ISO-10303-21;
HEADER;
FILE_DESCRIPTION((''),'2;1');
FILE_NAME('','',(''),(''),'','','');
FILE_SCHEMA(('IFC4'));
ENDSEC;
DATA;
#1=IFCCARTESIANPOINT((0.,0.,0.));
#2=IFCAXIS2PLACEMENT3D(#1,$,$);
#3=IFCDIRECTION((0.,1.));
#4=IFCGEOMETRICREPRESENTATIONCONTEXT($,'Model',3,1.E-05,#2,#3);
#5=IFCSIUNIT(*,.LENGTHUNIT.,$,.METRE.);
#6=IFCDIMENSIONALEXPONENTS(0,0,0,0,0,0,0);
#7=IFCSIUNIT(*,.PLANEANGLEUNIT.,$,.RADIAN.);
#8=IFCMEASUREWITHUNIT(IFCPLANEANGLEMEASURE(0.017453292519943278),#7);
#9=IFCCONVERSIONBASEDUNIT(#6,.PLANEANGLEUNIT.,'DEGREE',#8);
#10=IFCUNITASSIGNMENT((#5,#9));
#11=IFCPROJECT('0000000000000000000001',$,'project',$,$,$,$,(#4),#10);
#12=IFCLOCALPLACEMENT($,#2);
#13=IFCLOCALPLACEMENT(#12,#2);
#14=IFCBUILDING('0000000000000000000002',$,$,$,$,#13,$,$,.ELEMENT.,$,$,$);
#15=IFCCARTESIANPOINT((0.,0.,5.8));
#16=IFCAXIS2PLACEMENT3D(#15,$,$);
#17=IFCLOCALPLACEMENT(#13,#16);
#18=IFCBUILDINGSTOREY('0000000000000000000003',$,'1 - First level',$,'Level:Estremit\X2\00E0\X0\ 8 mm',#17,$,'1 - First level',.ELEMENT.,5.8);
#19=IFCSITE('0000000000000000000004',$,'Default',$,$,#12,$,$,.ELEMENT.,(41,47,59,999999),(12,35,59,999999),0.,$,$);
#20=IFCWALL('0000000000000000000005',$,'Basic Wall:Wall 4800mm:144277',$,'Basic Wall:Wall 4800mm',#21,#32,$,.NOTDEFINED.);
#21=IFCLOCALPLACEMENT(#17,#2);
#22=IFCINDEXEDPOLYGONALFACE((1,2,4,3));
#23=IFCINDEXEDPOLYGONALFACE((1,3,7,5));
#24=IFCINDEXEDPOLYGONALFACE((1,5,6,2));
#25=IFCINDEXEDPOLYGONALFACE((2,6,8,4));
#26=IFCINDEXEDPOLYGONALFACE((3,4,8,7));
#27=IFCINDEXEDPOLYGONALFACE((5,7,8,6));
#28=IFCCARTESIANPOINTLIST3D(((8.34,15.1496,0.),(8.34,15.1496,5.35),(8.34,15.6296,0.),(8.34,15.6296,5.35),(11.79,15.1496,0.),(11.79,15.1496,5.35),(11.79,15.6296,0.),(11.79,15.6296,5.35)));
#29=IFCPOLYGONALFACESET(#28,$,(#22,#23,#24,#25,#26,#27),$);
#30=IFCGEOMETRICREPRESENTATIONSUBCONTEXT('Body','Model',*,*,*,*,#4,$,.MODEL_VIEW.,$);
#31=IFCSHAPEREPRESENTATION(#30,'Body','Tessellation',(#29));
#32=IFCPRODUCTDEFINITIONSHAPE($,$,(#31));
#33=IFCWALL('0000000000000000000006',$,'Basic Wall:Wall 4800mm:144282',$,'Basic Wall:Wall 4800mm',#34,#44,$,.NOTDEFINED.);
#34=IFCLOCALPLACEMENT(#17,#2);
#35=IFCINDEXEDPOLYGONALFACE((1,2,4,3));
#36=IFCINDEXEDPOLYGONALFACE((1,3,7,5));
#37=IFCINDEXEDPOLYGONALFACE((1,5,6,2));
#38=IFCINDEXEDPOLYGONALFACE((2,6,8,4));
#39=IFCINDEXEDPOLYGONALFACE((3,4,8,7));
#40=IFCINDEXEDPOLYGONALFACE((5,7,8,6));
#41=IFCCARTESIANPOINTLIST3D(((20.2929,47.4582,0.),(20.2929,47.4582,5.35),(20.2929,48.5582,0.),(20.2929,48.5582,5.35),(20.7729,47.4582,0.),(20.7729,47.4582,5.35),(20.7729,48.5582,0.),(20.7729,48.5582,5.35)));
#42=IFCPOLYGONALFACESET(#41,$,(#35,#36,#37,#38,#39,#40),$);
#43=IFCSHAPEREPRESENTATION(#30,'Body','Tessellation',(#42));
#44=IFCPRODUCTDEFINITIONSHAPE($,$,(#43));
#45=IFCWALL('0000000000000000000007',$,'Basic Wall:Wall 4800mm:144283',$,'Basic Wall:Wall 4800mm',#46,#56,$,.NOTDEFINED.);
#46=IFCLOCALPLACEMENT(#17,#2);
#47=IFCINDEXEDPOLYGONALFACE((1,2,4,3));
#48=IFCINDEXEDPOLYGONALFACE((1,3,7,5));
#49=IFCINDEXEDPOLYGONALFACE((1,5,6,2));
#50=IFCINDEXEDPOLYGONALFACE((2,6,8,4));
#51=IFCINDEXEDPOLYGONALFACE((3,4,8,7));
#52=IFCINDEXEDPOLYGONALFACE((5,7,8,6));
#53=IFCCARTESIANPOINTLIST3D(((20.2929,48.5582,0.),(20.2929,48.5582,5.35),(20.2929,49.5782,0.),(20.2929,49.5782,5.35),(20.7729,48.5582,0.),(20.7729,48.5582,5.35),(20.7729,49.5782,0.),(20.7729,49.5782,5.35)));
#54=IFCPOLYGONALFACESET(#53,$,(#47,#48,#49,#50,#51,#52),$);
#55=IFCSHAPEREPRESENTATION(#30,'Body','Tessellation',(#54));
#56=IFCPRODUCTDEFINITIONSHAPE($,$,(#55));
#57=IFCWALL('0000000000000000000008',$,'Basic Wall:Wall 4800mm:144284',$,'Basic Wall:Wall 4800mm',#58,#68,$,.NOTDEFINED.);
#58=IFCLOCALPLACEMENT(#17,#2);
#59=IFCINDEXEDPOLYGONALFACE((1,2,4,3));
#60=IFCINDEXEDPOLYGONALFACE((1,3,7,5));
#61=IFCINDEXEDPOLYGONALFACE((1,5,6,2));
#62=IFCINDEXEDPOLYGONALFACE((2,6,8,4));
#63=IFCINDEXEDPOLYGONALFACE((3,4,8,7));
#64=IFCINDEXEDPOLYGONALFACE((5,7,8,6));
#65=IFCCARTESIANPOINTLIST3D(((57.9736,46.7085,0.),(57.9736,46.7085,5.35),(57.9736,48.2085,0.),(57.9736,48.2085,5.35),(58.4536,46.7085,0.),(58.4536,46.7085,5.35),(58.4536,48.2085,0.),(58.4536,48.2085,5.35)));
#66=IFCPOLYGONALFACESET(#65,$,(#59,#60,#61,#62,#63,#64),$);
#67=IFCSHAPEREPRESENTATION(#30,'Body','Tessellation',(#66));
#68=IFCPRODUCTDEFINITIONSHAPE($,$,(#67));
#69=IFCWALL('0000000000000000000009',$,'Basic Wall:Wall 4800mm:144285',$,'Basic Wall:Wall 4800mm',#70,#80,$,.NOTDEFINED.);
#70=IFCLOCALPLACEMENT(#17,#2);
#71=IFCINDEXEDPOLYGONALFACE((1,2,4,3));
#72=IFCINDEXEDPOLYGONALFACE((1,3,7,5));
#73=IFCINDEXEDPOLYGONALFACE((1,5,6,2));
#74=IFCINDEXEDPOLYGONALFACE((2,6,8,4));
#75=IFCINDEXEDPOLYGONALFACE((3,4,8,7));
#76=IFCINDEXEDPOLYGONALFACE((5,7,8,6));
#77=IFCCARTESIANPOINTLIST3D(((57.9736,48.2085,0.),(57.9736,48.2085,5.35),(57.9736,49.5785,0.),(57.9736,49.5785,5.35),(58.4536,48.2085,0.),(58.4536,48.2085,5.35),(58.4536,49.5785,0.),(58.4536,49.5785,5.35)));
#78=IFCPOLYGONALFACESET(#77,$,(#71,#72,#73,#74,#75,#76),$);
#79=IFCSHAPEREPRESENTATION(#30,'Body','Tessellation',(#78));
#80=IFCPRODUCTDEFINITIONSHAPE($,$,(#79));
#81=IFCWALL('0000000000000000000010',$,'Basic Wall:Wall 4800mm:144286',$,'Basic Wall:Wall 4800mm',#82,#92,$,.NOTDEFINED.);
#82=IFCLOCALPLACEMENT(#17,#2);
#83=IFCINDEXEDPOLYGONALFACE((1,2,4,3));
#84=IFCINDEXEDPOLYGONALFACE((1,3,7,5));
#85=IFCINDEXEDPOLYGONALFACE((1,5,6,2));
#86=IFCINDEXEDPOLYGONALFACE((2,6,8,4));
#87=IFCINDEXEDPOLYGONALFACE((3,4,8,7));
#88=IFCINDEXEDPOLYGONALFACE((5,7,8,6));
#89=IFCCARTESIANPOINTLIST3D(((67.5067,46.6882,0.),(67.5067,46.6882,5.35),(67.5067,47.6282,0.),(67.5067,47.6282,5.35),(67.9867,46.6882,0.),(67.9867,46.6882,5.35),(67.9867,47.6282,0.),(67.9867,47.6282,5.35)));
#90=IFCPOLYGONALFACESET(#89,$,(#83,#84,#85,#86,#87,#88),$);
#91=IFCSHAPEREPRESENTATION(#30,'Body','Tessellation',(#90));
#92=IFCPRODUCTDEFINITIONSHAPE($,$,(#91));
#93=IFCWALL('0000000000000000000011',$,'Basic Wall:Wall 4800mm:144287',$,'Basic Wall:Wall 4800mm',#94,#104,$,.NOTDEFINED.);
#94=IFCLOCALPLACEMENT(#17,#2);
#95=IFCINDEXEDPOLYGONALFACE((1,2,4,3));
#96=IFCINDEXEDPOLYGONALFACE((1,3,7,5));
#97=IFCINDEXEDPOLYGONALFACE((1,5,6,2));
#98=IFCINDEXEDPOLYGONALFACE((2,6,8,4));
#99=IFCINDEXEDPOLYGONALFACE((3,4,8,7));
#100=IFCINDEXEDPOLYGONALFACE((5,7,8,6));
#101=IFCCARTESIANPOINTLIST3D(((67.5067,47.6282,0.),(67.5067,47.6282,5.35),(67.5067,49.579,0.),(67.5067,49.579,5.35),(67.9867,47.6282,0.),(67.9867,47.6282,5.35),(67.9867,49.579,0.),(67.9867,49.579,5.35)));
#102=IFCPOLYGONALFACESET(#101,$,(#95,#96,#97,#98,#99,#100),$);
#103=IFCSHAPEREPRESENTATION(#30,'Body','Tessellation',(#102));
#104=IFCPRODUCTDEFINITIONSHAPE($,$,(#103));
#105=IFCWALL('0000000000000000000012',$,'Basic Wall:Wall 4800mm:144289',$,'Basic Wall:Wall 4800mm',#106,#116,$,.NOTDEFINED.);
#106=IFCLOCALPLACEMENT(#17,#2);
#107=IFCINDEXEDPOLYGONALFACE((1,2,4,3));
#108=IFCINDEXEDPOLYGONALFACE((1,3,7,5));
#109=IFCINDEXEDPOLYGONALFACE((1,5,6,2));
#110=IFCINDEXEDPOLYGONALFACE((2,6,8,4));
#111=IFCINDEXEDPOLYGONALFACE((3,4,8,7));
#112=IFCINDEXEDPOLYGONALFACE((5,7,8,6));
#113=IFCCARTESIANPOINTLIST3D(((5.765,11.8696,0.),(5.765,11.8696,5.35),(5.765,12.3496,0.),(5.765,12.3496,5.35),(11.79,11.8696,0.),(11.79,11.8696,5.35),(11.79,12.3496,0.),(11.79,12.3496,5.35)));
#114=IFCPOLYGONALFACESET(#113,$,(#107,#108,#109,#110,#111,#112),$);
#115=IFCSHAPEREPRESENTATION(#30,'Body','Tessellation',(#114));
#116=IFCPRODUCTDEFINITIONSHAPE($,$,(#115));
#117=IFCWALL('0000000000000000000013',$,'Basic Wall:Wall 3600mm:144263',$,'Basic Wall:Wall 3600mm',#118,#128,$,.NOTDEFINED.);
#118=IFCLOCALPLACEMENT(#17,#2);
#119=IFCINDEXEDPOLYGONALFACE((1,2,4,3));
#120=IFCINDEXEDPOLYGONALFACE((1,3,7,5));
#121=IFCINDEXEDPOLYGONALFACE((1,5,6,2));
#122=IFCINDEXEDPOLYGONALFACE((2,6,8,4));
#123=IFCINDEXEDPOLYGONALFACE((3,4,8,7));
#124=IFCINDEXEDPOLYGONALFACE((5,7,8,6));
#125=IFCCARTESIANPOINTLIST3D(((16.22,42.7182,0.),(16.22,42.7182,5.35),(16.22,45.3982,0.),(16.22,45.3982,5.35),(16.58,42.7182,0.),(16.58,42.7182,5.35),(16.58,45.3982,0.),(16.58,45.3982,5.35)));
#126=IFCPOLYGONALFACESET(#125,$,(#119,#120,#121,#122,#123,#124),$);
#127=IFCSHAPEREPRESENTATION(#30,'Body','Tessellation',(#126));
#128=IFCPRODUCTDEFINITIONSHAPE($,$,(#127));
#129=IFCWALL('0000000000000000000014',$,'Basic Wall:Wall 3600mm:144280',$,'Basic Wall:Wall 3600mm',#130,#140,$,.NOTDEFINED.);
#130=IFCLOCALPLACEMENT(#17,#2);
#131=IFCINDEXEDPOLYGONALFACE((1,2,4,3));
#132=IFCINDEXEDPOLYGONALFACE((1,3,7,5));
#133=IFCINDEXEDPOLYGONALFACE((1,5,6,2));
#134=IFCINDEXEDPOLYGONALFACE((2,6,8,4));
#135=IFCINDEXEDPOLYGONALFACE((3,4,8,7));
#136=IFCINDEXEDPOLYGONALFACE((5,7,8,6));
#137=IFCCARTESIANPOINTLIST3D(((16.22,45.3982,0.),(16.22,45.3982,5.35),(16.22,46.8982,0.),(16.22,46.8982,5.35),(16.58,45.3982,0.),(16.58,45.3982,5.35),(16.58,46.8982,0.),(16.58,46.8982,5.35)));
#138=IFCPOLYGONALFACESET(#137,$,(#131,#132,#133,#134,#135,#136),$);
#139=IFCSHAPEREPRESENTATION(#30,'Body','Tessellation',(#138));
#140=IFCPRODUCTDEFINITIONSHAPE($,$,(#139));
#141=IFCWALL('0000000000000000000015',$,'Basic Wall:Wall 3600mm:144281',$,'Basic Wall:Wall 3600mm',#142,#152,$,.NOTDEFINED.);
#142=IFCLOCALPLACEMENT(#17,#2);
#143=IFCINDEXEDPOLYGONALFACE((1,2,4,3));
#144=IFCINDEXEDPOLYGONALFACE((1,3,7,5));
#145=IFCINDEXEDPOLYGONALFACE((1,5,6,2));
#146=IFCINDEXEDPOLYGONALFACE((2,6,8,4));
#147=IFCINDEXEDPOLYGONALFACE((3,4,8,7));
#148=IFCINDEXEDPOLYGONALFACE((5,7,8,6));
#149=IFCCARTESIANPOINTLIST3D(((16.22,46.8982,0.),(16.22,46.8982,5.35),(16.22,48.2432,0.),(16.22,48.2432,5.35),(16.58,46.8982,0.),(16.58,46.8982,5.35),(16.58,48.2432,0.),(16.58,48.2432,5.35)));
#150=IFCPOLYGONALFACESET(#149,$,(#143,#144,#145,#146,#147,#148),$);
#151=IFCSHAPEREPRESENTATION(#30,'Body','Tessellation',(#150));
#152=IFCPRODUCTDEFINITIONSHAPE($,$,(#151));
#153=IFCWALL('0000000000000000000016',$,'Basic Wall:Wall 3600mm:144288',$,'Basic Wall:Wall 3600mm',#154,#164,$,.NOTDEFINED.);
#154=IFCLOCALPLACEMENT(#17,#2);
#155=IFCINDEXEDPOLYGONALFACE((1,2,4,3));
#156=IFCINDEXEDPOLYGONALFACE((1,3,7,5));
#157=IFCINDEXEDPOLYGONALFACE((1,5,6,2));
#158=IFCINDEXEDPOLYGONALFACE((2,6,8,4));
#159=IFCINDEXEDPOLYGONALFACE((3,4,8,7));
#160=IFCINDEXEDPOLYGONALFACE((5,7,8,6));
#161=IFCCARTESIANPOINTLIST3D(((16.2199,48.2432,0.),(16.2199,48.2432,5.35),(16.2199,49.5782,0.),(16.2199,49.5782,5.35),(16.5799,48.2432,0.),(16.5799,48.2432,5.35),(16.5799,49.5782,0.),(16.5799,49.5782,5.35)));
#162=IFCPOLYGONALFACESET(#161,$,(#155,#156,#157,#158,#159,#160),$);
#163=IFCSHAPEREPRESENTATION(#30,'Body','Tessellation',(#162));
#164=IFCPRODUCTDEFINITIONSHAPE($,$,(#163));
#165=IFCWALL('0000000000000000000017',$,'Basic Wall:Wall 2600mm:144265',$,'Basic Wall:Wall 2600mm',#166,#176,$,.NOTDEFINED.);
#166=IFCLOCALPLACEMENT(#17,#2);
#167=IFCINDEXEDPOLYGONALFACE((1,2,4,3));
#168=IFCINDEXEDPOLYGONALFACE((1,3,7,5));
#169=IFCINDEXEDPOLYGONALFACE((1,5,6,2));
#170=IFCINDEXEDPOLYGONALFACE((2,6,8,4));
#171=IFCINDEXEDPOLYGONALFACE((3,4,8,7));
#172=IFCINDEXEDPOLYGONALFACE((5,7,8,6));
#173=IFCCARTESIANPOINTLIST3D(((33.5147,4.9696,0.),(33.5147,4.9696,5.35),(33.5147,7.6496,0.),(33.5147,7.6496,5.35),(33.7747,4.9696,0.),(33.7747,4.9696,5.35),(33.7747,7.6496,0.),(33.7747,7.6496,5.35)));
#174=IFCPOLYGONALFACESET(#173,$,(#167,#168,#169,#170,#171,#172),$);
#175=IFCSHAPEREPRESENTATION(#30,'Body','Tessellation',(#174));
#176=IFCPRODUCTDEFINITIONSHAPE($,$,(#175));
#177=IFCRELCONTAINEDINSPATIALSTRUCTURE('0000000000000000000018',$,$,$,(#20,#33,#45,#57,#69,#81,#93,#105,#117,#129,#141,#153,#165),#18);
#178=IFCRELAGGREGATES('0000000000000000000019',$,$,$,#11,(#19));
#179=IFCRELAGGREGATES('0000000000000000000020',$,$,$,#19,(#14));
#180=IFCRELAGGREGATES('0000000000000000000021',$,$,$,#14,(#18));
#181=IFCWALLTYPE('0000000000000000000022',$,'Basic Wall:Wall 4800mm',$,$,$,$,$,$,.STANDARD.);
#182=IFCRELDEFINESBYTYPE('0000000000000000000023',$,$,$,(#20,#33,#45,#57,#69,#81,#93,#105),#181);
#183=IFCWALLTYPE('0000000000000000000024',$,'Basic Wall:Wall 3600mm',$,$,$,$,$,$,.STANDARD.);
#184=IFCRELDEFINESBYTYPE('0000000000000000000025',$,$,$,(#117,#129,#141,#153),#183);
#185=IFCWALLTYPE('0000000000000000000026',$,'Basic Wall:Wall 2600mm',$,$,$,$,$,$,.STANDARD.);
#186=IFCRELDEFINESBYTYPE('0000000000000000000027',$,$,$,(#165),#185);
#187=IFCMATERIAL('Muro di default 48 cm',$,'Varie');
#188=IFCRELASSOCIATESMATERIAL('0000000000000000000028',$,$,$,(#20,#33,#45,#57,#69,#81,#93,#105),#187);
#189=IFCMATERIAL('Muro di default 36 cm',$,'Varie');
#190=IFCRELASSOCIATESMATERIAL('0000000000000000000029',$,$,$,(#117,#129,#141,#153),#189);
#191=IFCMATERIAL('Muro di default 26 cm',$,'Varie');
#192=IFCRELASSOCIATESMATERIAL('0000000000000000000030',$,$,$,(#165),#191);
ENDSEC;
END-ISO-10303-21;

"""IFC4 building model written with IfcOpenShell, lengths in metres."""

from ifc_helpers import new_model, entity, si_unit, converted_unit, direction, frame, origin, place, context, subcontext, project, spatial, indexed_curve, outline, extrude, material, type_object, element, save


model = new_model("IFC4")

# Units and contexts
model_context = context("Model", 3, precision=1e-05, world=origin(), true_north=direction((0.0, 1.0)))
body_context = subcontext(model_context, "Body", "Model", "MODEL_VIEW")
ifc_project = project(units=[si_unit("LENGTHUNIT", "METRE"), converted_unit("PLANEANGLEUNIT", "DEGREE", entity("IfcPlaneAngleMeasure", 0.017453292519943278), si_unit("PLANEANGLEUNIT", "RADIAN"), dimensions=[0, 0, 0, 0, 0, 0, 0])], contexts=[model_context])

# Site, building, storey
site_placement = place(None, origin())
site = spatial("IfcSite", under=ifc_project, at=site_placement, Name="Default", CompositionType="ELEMENT", RefLatitude=(41, 47, 59, 999999), RefLongitude=(12, 35, 59, 999999), RefElevation=0.0)
building_placement = place(site_placement, origin())
building = spatial("IfcBuilding", under=site, at=building_placement, CompositionType="ELEMENT")
storey_placement = place(building_placement, frame((0.0, 0.0, 5.8)))
storey = spatial("IfcBuildingStorey", under=building, at=storey_placement, Name="1 - First level", ObjectType="Level:Estremità 8 mm", LongName="1 - First level", CompositionType="ELEMENT", Elevation=5.8)

# Walls
ifc_material_1 = material(Name="Muro di default 48 cm", Category="Varie")
wall_type_1 = type_object("IfcWallType", Name="Basic Wall:Wall 4800mm", PredefinedType="STANDARD")
wall_1_placement = place(storey_placement, frame((8.34, 15.3896, 0.0)))
element("IfcWall", 1, at=wall_1_placement, inside=storey, type_object=wall_type_1, material=ifc_material_1, Name="Basic Wall:Wall 4800mm:144277", ObjectType="Basic Wall:Wall 4800mm", PredefinedType="NOTDEFINED", context=body_context, shape_type="SweptSolid", body=[
    extrude(outline(indexed_curve([(3.45, 0.24), (0.0, 0.24), (0.0, -0.24), (3.45, -0.24), (3.45, 0.24)], self_intersect=False)), origin(), (0.0, 0.0, 1.0), 5.35),
])
wall_2_placement = place(storey_placement, frame((20.5329, 47.4582, 0.0), z_axis=(0.0, 0.0, 1.0), x_axis=(0.0, 1.0, 0.0)))
element("IfcWall", 2, at=wall_2_placement, inside=storey, type_object=wall_type_1, material=ifc_material_1, Name="Basic Wall:Wall 4800mm:144282", ObjectType="Basic Wall:Wall 4800mm", PredefinedType="NOTDEFINED", context=body_context, shape_type="SweptSolid", body=[
    extrude(outline(indexed_curve([(1.1, 0.24), (0.0, 0.24), (0.0, -0.24), (1.1, -0.24), (1.1, 0.24)], self_intersect=False)), origin(), (0.0, 0.0, 1.0), 5.35),
])
wall_3_placement = place(storey_placement, frame((20.5329, 48.5582, 0.0), z_axis=(0.0, 0.0, 1.0), x_axis=(0.0, 1.0, 0.0)))
element("IfcWall", 3, at=wall_3_placement, inside=storey, type_object=wall_type_1, material=ifc_material_1, Name="Basic Wall:Wall 4800mm:144283", ObjectType="Basic Wall:Wall 4800mm", PredefinedType="NOTDEFINED", context=body_context, shape_type="SweptSolid", body=[
    extrude(outline(indexed_curve([(1.02, 0.24), (0.0, 0.24), (0.0, -0.24), (1.02, -0.24), (1.02, 0.24)], self_intersect=False)), origin(), (0.0, 0.0, 1.0), 5.35),
])
wall_4_placement = place(storey_placement, frame((58.2136, 46.7085, 0.0), z_axis=(0.0, 0.0, 1.0), x_axis=(0.0, 1.0, 0.0)))
element("IfcWall", 4, at=wall_4_placement, inside=storey, type_object=wall_type_1, material=ifc_material_1, Name="Basic Wall:Wall 4800mm:144284", ObjectType="Basic Wall:Wall 4800mm", PredefinedType="NOTDEFINED", context=body_context, shape_type="SweptSolid", body=[
    extrude(outline(indexed_curve([(1.5, 0.24), (0.0, 0.24), (0.0, -0.24), (1.5, -0.24), (1.5, 0.24)], self_intersect=False)), origin(), (0.0, 0.0, 1.0), 5.35),
])
wall_5_placement = place(storey_placement, frame((58.2136, 48.2085, 0.0), z_axis=(0.0, 0.0, 1.0), x_axis=(0.0, 1.0, 0.0)))
element("IfcWall", 5, at=wall_5_placement, inside=storey, type_object=wall_type_1, material=ifc_material_1, Name="Basic Wall:Wall 4800mm:144285", ObjectType="Basic Wall:Wall 4800mm", PredefinedType="NOTDEFINED", context=body_context, shape_type="SweptSolid", body=[
    extrude(outline(indexed_curve([(1.37, 0.24), (0.0, 0.24), (0.0, -0.24), (1.37, -0.24), (1.37, 0.24)], self_intersect=False)), origin(), (0.0, 0.0, 1.0), 5.35),
])
wall_6_placement = place(storey_placement, frame((67.7467, 46.6882, 0.0), z_axis=(0.0, 0.0, 1.0), x_axis=(0.0, 1.0, 0.0)))
element("IfcWall", 6, at=wall_6_placement, inside=storey, type_object=wall_type_1, material=ifc_material_1, Name="Basic Wall:Wall 4800mm:144286", ObjectType="Basic Wall:Wall 4800mm", PredefinedType="NOTDEFINED", context=body_context, shape_type="SweptSolid", body=[
    extrude(outline(indexed_curve([(0.94, 0.24), (0.0, 0.24), (0.0, -0.24), (0.94, -0.24), (0.94, 0.24)], self_intersect=False)), origin(), (0.0, 0.0, 1.0), 5.35),
])
wall_7_placement = place(storey_placement, frame((67.7467, 47.6282, 0.0), z_axis=(0.0, 0.0, 1.0), x_axis=(0.0, 1.0, 0.0)))
element("IfcWall", 7, at=wall_7_placement, inside=storey, type_object=wall_type_1, material=ifc_material_1, Name="Basic Wall:Wall 4800mm:144287", ObjectType="Basic Wall:Wall 4800mm", PredefinedType="NOTDEFINED", context=body_context, shape_type="SweptSolid", body=[
    extrude(outline(indexed_curve([(1.9508, 0.24), (0.0, 0.24), (0.0, -0.24), (1.9508, -0.24), (1.9508, 0.24)], self_intersect=False)), origin(), (0.0, 0.0, 1.0), 5.35),
])
wall_8_placement = place(storey_placement, frame((5.765, 12.1096, 0.0)))
element("IfcWall", 8, at=wall_8_placement, inside=storey, type_object=wall_type_1, material=ifc_material_1, Name="Basic Wall:Wall 4800mm:144289", ObjectType="Basic Wall:Wall 4800mm", PredefinedType="NOTDEFINED", context=body_context, shape_type="SweptSolid", body=[
    extrude(outline(indexed_curve([(6.025, 0.24), (0.0, 0.24), (0.0, -0.24), (6.025, -0.24), (6.025, 0.24)], self_intersect=False)), origin(), (0.0, 0.0, 1.0), 5.35),
])
ifc_material_2 = material(Name="Muro di default 36 cm", Category="Varie")
wall_type_2 = type_object("IfcWallType", Name="Basic Wall:Wall 3600mm", PredefinedType="STANDARD")
wall_9_placement = place(storey_placement, frame((16.4, 42.7182, 0.0), z_axis=(0.0, 0.0, 1.0), x_axis=(0.0, 1.0, 0.0)))
element("IfcWall", 9, at=wall_9_placement, inside=storey, type_object=wall_type_2, material=ifc_material_2, Name="Basic Wall:Wall 3600mm:144263", ObjectType="Basic Wall:Wall 3600mm", PredefinedType="NOTDEFINED", context=body_context, shape_type="SweptSolid", body=[
    extrude(outline(indexed_curve([(2.68, 0.18), (0.0, 0.18), (0.0, -0.18), (2.68, -0.18), (2.68, 0.18)], self_intersect=False)), origin(), (0.0, 0.0, 1.0), 5.35),
])
wall_10_placement = place(storey_placement, frame((16.4, 45.3982, 0.0), z_axis=(0.0, 0.0, 1.0), x_axis=(0.0, 1.0, 0.0)))
element("IfcWall", 10, at=wall_10_placement, inside=storey, type_object=wall_type_2, material=ifc_material_2, Name="Basic Wall:Wall 3600mm:144280", ObjectType="Basic Wall:Wall 3600mm", PredefinedType="NOTDEFINED", context=body_context, shape_type="SweptSolid", body=[
    extrude(outline(indexed_curve([(1.5, 0.18), (0.0, 0.18), (0.0, -0.18), (1.5, -0.18), (1.5, 0.18)], self_intersect=False)), origin(), (0.0, 0.0, 1.0), 5.35),
])
wall_11_placement = place(storey_placement, frame((16.4, 46.8982, 0.0), z_axis=(0.0, 0.0, 1.0), x_axis=(0.0, 1.0, 0.0)))
element("IfcWall", 11, at=wall_11_placement, inside=storey, type_object=wall_type_2, material=ifc_material_2, Name="Basic Wall:Wall 3600mm:144281", ObjectType="Basic Wall:Wall 3600mm", PredefinedType="NOTDEFINED", context=body_context, shape_type="SweptSolid", body=[
    extrude(outline(indexed_curve([(1.345, 0.18), (0.0, 0.18), (0.0, -0.18), (1.345, -0.18), (1.345, 0.18)], self_intersect=False)), origin(), (0.0, 0.0, 1.0), 5.35),
])
wall_12_placement = place(storey_placement, frame((16.3999, 48.2432, 0.0), z_axis=(0.0, 0.0, 1.0), x_axis=(0.0, 1.0, 0.0)))
element("IfcWall", 12, at=wall_12_placement, inside=storey, type_object=wall_type_2, material=ifc_material_2, Name="Basic Wall:Wall 3600mm:144288", ObjectType="Basic Wall:Wall 3600mm", PredefinedType="NOTDEFINED", context=body_context, shape_type="SweptSolid", body=[
    extrude(outline(indexed_curve([(1.335, 0.18), (0.0, 0.18), (0.0, -0.18), (1.335, -0.18), (1.335, 0.18)], self_intersect=False)), origin(), (0.0, 0.0, 1.0), 5.35),
])
ifc_material_3 = material(Name="Muro di default 26 cm", Category="Varie")
wall_type_3 = type_object("IfcWallType", Name="Basic Wall:Wall 2600mm", PredefinedType="STANDARD")
wall_13_placement = place(storey_placement, frame((33.6447, 4.9696, 0.0), z_axis=(0.0, 0.0, 1.0), x_axis=(0.0, 1.0, 0.0)))
element("IfcWall", 13, at=wall_13_placement, inside=storey, type_object=wall_type_3, material=ifc_material_3, Name="Basic Wall:Wall 2600mm:144265", ObjectType="Basic Wall:Wall 2600mm", PredefinedType="NOTDEFINED", context=body_context, shape_type="SweptSolid", body=[
    extrude(outline(indexed_curve([(2.68, 0.13), (0.0, 0.13), (0.0, -0.13), (2.68, -0.13), (2.68, 0.13)], self_intersect=False)), origin(), (0.0, 0.0, 1.0), 5.35),
])

save(model, "model.ifc")
